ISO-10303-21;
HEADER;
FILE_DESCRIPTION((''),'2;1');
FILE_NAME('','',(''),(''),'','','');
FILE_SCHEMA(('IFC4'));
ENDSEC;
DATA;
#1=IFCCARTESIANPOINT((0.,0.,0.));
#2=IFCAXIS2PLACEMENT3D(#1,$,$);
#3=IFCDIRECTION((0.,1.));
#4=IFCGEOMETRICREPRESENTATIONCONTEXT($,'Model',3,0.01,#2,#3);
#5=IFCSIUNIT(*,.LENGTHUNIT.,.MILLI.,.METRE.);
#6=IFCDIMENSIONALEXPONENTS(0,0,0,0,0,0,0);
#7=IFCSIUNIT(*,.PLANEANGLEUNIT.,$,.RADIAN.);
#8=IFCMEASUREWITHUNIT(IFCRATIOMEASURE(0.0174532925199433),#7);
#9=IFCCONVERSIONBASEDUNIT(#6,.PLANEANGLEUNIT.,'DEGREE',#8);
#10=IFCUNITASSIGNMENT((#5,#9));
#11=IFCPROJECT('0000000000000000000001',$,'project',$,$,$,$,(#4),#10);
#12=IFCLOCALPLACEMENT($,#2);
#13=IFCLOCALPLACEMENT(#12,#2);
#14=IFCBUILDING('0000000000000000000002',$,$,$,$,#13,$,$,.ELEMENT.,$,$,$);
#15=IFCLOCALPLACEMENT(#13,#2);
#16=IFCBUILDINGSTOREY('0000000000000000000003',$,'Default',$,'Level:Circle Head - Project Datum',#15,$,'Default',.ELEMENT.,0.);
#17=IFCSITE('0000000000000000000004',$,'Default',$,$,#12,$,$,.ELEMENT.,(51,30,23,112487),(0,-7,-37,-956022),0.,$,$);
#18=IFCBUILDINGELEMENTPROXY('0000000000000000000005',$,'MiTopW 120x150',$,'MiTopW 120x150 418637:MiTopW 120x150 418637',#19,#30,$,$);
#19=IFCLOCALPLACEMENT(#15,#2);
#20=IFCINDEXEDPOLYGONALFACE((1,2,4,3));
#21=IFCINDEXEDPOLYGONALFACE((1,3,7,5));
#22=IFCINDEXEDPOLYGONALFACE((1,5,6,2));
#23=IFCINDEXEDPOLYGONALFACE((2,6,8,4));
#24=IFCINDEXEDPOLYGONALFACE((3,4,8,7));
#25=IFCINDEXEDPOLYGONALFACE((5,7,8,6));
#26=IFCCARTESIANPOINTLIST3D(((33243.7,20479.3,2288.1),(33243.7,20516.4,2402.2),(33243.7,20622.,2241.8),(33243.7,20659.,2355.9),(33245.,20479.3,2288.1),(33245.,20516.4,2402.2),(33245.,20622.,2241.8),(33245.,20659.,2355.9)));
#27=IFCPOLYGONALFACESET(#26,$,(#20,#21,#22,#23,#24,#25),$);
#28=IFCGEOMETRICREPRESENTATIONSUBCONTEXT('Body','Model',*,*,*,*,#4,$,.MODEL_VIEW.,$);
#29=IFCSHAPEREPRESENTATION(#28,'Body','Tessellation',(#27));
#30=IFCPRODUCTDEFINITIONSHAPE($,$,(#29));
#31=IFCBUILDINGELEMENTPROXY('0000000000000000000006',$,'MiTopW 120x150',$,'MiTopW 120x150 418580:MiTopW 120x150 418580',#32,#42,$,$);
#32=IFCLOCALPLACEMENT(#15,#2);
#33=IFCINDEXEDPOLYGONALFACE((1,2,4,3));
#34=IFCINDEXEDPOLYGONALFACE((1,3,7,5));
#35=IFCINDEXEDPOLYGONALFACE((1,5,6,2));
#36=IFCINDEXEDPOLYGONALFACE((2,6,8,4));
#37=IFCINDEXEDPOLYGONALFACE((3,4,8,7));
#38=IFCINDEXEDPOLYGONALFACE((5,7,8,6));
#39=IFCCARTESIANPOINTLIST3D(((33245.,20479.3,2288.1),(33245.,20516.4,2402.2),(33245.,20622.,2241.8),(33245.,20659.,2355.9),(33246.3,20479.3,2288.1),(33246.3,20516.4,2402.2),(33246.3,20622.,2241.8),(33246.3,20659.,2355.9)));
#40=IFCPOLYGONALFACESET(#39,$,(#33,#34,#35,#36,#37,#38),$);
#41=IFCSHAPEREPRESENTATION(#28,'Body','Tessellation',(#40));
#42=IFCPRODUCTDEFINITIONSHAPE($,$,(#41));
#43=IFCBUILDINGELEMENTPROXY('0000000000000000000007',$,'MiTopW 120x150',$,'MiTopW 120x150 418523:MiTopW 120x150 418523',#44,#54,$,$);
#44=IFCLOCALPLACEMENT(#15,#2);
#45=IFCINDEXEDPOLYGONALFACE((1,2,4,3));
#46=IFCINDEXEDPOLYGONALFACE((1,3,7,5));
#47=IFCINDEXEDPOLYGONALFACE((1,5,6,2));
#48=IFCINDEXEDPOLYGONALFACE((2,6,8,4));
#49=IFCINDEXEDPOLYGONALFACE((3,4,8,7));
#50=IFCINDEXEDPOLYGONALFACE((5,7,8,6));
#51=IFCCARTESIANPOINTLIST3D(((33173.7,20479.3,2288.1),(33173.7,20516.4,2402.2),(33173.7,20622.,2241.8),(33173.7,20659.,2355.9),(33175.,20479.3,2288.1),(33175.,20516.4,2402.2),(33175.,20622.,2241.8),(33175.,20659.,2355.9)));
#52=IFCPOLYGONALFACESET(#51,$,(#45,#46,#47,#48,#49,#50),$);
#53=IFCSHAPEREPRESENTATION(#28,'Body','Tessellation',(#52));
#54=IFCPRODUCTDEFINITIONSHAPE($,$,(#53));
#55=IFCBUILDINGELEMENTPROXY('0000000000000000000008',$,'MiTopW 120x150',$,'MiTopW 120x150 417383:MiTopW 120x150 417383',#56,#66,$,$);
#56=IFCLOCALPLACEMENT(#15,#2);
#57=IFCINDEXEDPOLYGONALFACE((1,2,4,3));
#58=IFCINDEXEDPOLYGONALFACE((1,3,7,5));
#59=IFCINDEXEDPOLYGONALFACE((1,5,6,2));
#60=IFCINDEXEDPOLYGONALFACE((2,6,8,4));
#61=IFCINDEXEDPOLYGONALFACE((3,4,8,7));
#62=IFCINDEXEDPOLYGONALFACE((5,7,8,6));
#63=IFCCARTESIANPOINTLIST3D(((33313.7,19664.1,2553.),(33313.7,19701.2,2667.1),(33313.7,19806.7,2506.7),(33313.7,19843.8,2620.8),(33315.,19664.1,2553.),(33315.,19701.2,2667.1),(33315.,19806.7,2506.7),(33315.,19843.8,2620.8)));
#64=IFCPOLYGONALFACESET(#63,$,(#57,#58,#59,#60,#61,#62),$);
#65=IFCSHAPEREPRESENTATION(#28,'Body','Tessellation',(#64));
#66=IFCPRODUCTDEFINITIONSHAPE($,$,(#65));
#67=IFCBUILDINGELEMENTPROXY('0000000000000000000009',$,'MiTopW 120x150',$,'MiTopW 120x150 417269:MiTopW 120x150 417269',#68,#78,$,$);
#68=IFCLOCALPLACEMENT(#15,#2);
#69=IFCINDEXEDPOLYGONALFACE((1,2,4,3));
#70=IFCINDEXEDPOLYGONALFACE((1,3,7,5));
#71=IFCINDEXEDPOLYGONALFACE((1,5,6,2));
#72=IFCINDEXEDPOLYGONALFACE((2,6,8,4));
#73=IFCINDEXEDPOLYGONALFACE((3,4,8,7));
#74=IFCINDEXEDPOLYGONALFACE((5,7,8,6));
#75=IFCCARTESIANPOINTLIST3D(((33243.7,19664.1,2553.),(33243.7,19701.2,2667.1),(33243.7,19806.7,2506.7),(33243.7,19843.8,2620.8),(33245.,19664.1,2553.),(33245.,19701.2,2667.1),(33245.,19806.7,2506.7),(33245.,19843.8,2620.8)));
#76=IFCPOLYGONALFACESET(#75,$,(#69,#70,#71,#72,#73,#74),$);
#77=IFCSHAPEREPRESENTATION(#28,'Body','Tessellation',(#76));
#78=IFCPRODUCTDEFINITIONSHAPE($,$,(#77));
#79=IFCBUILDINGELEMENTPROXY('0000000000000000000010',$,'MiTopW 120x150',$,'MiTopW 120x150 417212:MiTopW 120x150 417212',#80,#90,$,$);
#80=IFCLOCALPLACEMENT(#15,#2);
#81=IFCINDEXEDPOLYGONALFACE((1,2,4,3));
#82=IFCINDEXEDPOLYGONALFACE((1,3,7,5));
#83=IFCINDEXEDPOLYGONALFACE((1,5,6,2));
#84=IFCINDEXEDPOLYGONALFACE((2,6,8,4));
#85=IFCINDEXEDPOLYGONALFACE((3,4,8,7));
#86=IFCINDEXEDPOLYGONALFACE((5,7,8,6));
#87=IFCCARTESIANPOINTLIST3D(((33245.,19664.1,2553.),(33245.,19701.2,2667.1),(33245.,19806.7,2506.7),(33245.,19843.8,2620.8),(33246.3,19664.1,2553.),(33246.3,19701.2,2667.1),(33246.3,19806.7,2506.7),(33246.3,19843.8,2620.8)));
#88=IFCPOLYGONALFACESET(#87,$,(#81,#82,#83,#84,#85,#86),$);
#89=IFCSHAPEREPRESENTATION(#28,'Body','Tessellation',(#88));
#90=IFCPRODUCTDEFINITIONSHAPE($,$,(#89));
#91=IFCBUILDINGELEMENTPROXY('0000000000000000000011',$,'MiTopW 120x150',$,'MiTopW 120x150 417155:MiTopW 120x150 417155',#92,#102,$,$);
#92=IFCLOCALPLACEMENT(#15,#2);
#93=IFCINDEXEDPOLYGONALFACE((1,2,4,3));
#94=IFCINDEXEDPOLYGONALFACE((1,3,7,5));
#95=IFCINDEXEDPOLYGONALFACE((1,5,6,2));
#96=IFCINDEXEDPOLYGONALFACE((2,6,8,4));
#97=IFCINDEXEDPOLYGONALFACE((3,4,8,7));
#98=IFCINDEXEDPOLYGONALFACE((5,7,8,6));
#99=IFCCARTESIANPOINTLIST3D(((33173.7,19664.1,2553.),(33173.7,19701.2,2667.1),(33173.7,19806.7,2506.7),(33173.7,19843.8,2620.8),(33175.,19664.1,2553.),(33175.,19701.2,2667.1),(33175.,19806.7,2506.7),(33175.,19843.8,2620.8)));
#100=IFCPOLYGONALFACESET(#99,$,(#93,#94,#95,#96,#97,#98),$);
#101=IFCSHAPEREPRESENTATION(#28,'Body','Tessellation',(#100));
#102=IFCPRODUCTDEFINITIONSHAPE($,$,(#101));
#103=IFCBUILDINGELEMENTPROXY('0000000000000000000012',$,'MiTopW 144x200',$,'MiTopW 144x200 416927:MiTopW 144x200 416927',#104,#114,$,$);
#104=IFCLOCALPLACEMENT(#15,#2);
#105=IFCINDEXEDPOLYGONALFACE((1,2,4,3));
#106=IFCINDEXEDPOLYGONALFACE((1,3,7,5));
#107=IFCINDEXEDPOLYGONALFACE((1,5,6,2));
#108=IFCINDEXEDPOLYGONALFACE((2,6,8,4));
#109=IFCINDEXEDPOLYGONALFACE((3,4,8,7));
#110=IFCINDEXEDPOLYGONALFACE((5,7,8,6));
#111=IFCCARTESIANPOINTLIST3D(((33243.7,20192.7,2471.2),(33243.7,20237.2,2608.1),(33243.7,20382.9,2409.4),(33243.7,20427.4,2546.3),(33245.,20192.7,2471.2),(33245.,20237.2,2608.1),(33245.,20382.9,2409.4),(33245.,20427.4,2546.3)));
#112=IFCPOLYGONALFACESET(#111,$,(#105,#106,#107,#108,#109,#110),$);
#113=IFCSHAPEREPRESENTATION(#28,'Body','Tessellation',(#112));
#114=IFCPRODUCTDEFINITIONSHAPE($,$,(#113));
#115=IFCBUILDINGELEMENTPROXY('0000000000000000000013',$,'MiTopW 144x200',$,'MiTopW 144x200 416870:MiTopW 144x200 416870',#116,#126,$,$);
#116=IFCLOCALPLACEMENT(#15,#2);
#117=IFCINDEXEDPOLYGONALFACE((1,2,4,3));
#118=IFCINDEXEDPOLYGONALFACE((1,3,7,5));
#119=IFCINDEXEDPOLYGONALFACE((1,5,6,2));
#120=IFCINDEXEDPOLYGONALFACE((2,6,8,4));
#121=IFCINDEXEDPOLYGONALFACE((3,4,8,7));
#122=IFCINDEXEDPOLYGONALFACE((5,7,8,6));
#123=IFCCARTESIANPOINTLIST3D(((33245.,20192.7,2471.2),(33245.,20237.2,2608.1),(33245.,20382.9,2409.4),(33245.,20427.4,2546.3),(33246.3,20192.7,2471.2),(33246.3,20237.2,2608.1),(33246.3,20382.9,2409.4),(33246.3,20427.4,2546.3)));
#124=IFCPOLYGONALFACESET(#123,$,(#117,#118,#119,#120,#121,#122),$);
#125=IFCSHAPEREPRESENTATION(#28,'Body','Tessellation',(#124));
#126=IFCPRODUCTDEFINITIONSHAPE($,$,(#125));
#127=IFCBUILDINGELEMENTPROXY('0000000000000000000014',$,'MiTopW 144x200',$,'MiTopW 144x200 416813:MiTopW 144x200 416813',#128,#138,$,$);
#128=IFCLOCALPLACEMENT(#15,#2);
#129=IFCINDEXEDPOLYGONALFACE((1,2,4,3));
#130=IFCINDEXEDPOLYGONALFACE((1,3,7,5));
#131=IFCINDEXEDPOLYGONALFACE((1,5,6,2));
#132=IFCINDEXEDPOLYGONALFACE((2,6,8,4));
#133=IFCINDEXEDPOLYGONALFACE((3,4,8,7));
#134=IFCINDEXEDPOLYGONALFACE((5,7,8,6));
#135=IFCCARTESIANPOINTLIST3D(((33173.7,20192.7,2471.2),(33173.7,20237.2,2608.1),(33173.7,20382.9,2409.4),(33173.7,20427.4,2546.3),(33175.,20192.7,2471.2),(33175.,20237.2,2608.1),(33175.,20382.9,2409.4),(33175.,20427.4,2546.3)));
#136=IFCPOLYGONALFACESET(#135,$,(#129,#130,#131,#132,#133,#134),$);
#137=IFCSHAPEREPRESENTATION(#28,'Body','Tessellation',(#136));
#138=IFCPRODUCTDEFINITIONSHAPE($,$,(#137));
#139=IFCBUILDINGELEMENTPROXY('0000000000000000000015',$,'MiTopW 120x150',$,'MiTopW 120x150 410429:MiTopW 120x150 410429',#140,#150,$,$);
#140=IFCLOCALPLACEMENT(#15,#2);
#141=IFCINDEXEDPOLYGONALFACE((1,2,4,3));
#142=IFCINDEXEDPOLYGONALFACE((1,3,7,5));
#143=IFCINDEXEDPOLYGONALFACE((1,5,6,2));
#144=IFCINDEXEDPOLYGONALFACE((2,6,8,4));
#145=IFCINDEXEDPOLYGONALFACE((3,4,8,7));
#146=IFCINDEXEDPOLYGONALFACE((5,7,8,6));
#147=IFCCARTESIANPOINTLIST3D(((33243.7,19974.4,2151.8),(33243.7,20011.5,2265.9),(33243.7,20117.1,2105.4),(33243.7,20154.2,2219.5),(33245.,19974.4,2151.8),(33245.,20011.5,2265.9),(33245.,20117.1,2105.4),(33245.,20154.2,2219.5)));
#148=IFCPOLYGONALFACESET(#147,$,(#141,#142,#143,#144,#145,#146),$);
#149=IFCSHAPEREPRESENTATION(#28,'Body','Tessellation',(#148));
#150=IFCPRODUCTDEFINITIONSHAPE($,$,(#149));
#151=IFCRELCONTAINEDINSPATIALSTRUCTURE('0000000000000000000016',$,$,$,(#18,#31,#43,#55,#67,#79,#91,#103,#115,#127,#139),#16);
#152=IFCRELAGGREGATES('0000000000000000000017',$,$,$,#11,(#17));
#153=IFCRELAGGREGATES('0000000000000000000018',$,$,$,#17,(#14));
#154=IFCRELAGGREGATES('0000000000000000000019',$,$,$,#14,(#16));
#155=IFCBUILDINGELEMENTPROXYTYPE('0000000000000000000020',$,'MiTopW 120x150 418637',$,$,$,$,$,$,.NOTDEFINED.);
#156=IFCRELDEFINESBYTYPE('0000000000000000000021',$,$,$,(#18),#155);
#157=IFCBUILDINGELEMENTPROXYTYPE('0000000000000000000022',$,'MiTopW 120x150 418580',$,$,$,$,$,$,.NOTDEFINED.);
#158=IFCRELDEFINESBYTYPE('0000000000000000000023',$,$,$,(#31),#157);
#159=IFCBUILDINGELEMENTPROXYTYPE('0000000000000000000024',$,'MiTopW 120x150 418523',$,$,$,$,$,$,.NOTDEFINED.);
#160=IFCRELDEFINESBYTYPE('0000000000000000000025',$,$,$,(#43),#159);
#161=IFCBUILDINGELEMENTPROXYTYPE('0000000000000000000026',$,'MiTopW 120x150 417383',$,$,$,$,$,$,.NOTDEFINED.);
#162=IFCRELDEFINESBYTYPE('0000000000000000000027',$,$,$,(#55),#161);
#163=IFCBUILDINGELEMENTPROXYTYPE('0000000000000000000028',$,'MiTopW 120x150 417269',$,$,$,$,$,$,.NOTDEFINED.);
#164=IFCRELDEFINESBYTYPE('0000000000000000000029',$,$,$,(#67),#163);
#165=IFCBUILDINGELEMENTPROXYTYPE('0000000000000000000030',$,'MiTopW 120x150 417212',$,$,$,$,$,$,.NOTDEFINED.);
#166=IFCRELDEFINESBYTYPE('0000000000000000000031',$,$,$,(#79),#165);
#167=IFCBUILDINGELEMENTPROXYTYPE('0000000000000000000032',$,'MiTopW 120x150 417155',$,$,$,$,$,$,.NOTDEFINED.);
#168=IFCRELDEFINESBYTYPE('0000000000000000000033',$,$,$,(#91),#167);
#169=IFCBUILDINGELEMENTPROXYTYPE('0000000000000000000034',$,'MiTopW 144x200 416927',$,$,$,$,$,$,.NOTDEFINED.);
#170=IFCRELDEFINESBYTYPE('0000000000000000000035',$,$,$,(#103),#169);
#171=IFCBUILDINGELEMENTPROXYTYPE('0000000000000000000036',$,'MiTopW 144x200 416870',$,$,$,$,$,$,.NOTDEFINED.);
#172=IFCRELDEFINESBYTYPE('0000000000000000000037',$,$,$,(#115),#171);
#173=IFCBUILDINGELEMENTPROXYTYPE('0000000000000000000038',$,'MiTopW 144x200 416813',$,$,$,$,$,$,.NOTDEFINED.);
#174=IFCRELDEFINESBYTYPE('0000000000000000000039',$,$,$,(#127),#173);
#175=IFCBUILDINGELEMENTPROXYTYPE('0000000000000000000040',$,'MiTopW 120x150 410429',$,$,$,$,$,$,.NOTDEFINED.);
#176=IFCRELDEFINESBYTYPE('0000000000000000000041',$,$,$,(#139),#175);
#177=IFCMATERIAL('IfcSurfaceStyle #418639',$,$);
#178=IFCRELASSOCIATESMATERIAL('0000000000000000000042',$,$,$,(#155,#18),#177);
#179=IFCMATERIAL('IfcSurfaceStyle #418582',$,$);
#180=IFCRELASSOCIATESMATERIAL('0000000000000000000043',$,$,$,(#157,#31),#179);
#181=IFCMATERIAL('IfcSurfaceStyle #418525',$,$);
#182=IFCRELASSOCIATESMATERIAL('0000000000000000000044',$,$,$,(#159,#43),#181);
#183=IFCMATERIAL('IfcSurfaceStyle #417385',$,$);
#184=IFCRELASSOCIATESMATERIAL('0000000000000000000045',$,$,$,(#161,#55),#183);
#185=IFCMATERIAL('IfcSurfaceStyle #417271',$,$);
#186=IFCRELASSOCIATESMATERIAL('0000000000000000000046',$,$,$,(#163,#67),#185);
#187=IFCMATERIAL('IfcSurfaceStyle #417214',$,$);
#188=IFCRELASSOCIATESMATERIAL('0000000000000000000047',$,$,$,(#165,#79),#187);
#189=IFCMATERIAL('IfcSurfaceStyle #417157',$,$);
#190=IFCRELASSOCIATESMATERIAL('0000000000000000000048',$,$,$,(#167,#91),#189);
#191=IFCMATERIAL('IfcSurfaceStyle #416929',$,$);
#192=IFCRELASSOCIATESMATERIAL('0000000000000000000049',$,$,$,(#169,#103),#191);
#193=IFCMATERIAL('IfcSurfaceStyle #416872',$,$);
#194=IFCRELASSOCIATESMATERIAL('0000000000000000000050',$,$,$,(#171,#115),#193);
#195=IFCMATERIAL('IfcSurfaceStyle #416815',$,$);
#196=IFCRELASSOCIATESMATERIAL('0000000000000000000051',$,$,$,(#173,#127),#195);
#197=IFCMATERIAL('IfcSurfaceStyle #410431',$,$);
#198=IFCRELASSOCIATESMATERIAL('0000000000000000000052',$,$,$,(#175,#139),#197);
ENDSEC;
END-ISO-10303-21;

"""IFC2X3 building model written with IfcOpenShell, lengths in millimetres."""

from ifc_helpers import new_model, entity, si_unit, converted_unit, direction, frame, origin, place, context, subcontext, project, spatial, polyline, outline, extrude, source, transform, mapped, material, type_object, type_shapes, element, save


model = new_model("IFC2X3")

# Units and contexts
model_context = context("Model", 3, precision=0.01, world=origin(), true_north=direction((0.0, 1.0)))
body_context = subcontext(model_context, "Body", "Model", "MODEL_VIEW")
ifc_project = project(units=[si_unit("LENGTHUNIT", "METRE", prefix="MILLI"), converted_unit("PLANEANGLEUNIT", "DEGREE", entity("IfcRatioMeasure", 0.0174532925199433), si_unit("PLANEANGLEUNIT", "RADIAN"), dimensions=[0, 0, 0, 0, 0, 0, 0])], contexts=[model_context])

# Site, building, storey
site_placement = place(None, origin())
site = spatial("IfcSite", under=ifc_project, at=site_placement, Name="Default", CompositionType="ELEMENT", RefLatitude=(51, 30, 23, 112487), RefLongitude=(0, -7, -37, -956022), RefElevation=0.0)
building_placement = place(site_placement, origin())
building = spatial("IfcBuilding", under=site, at=building_placement, CompositionType="ELEMENT")
storey_placement = place(building_placement, origin())
storey = spatial("IfcBuildingStorey", under=building, at=storey_placement, Name="Default", ObjectType="Level:Circle Head - Project Datum", LongName="Default", CompositionType="ELEMENT", Elevation=0.0)

# Building element proxies
ifc_material_1 = material(Name="IfcSurfaceStyle #418639")
building_element_proxy_type_1 = type_object("IfcBuildingElementProxyType", Name="MiTopW 120x150 418637", PredefinedType="NOTDEFINED", material=ifc_material_1)
shared_shape_1 = source(origin(), body_context, "Body", "SweptSolid", [
    extrude(outline(polyline([(-75.0, -60.0), (75.0, -60.0), (75.0, 60.0), (-75.0, 60.0), (-75.0, -60.0)])), frame((75.0, 60.0, 0.0), z_axis=(0.0, 0.0, 1.0), x_axis=(-1.0, 0.0, 0.0)), (0.0, 0.0, 1.0), 1.3),
])
type_shapes(building_element_proxy_type_1, [shared_shape_1])
proxy_1_placement = place(building_placement, frame((33245.0, 20622.0, 2241.8), z_axis=(-1.0, 0.0, 0.0), x_axis=(0.0, -0.951057, 0.309017)))
element("IfcBuildingElementProxy", 1, at=proxy_1_placement, inside=storey, type_object=building_element_proxy_type_1, material=ifc_material_1, Name="MiTopW 120x150", ObjectType="MiTopW 120x150 418637:MiTopW 120x150 418637", context=body_context, shape_type="MappedRepresentation", body=[
    mapped(shared_shape_1, transform((0.0, 0.0, 0.0), scale=1.0)),
])
ifc_material_2 = material(Name="IfcSurfaceStyle #418582")
building_element_proxy_type_2 = type_object("IfcBuildingElementProxyType", Name="MiTopW 120x150 418580", PredefinedType="NOTDEFINED", material=ifc_material_2)
shared_shape_2 = source(origin(), body_context, "Body", "SweptSolid", [
    extrude(outline(polyline([(-75.0, -60.0), (75.0, -60.0), (75.0, 60.0), (-75.0, 60.0), (-75.0, -60.0)])), frame((75.0, 60.0, 0.0), z_axis=(0.0, 0.0, 1.0), x_axis=(-1.0, 0.0, 0.0)), (0.0, 0.0, 1.0), 1.3),
])
type_shapes(building_element_proxy_type_2, [shared_shape_2])
proxy_2_placement = place(building_placement, frame((33246.3, 20622.0, 2241.8), z_axis=(-1.0, 0.0, 0.0), x_axis=(0.0, -0.951057, 0.309017)))
element("IfcBuildingElementProxy", 2, at=proxy_2_placement, inside=storey, type_object=building_element_proxy_type_2, material=ifc_material_2, Name="MiTopW 120x150", ObjectType="MiTopW 120x150 418580:MiTopW 120x150 418580", context=body_context, shape_type="MappedRepresentation", body=[
    mapped(shared_shape_2, transform((0.0, 0.0, 0.0), scale=1.0)),
])
ifc_material_3 = material(Name="IfcSurfaceStyle #418525")
building_element_proxy_type_3 = type_object("IfcBuildingElementProxyType", Name="MiTopW 120x150 418523", PredefinedType="NOTDEFINED", material=ifc_material_3)
shared_shape_3 = source(origin(), body_context, "Body", "SweptSolid", [
    extrude(outline(polyline([(-75.0, -60.0), (75.0, -60.0), (75.0, 60.0), (-75.0, 60.0), (-75.0, -60.0)])), frame((75.0, 60.0, 0.0), z_axis=(0.0, 0.0, 1.0), x_axis=(-1.0, 0.0, 0.0)), (0.0, 0.0, 1.0), 1.3),
])
type_shapes(building_element_proxy_type_3, [shared_shape_3])
proxy_3_placement = place(building_placement, frame((33175.0, 20622.0, 2241.8), z_axis=(-1.0, 0.0, 0.0), x_axis=(0.0, -0.951057, 0.309017)))
element("IfcBuildingElementProxy", 3, at=proxy_3_placement, inside=storey, type_object=building_element_proxy_type_3, material=ifc_material_3, Name="MiTopW 120x150", ObjectType="MiTopW 120x150 418523:MiTopW 120x150 418523", context=body_context, shape_type="MappedRepresentation", body=[
    mapped(shared_shape_3, transform((0.0, 0.0, 0.0), scale=1.0)),
])
ifc_material_4 = material(Name="IfcSurfaceStyle #417385")
building_element_proxy_type_4 = type_object("IfcBuildingElementProxyType", Name="MiTopW 120x150 417383", PredefinedType="NOTDEFINED", material=ifc_material_4)
shared_shape_4 = source(origin(), body_context, "Body", "SweptSolid", [
    extrude(outline(polyline([(-75.0, -60.0), (75.0, -60.0), (75.0, 60.0), (-75.0, 60.0), (-75.0, -60.0)])), frame((75.0, 60.0, 0.0), z_axis=(0.0, 0.0, 1.0), x_axis=(-1.0, 0.0, 0.0)), (0.0, 0.0, 1.0), 1.3),
])
type_shapes(building_element_proxy_type_4, [shared_shape_4])
proxy_4_placement = place(building_placement, frame((33315.0, 19806.7, 2506.7), z_axis=(-1.0, 0.0, 0.0), x_axis=(0.0, -0.951057, 0.309017)))
element("IfcBuildingElementProxy", 4, at=proxy_4_placement, inside=storey, type_object=building_element_proxy_type_4, material=ifc_material_4, Name="MiTopW 120x150", ObjectType="MiTopW 120x150 417383:MiTopW 120x150 417383", context=body_context, shape_type="MappedRepresentation", body=[
    mapped(shared_shape_4, transform((0.0, 0.0, 0.0), scale=1.0)),
])
ifc_material_5 = material(Name="IfcSurfaceStyle #417271")
building_element_proxy_type_5 = type_object("IfcBuildingElementProxyType", Name="MiTopW 120x150 417269", PredefinedType="NOTDEFINED", material=ifc_material_5)
shared_shape_5 = source(origin(), body_context, "Body", "SweptSolid", [
    extrude(outline(polyline([(-75.0, -60.0), (75.0, -60.0), (75.0, 60.0), (-75.0, 60.0), (-75.0, -60.0)])), frame((75.0, 60.0, 0.0), z_axis=(0.0, 0.0, 1.0), x_axis=(-1.0, 0.0, 0.0)), (0.0, 0.0, 1.0), 1.3),
])
type_shapes(building_element_proxy_type_5, [shared_shape_5])
proxy_5_placement = place(building_placement, frame((33245.0, 19806.7, 2506.7), z_axis=(-1.0, 0.0, 0.0), x_axis=(0.0, -0.951057, 0.309017)))
element("IfcBuildingElementProxy", 5, at=proxy_5_placement, inside=storey, type_object=building_element_proxy_type_5, material=ifc_material_5, Name="MiTopW 120x150", ObjectType="MiTopW 120x150 417269:MiTopW 120x150 417269", context=body_context, shape_type="MappedRepresentation", body=[
    mapped(shared_shape_5, transform((0.0, 0.0, 0.0), scale=1.0)),
])
ifc_material_6 = material(Name="IfcSurfaceStyle #417214")
building_element_proxy_type_6 = type_object("IfcBuildingElementProxyType", Name="MiTopW 120x150 417212", PredefinedType="NOTDEFINED", material=ifc_material_6)
shared_shape_6 = source(origin(), body_context, "Body", "SweptSolid", [
    extrude(outline(polyline([(-75.0, -60.0), (75.0, -60.0), (75.0, 60.0), (-75.0, 60.0), (-75.0, -60.0)])), frame((75.0, 60.0, 0.0), z_axis=(0.0, 0.0, 1.0), x_axis=(-1.0, 0.0, 0.0)), (0.0, 0.0, 1.0), 1.3),
])
type_shapes(building_element_proxy_type_6, [shared_shape_6])
proxy_6_placement = place(building_placement, frame((33246.3, 19806.7, 2506.7), z_axis=(-1.0, 0.0, 0.0), x_axis=(0.0, -0.951057, 0.309017)))
element("IfcBuildingElementProxy", 6, at=proxy_6_placement, inside=storey, type_object=building_element_proxy_type_6, material=ifc_material_6, Name="MiTopW 120x150", ObjectType="MiTopW 120x150 417212:MiTopW 120x150 417212", context=body_context, shape_type="MappedRepresentation", body=[
    mapped(shared_shape_6, transform((0.0, 0.0, 0.0), scale=1.0)),
])
ifc_material_7 = material(Name="IfcSurfaceStyle #417157")
building_element_proxy_type_7 = type_object("IfcBuildingElementProxyType", Name="MiTopW 120x150 417155", PredefinedType="NOTDEFINED", material=ifc_material_7)
shared_shape_7 = source(origin(), body_context, "Body", "SweptSolid", [
    extrude(outline(polyline([(-75.0, -60.0), (75.0, -60.0), (75.0, 60.0), (-75.0, 60.0), (-75.0, -60.0)])), frame((75.0, 60.0, 0.0), z_axis=(0.0, 0.0, 1.0), x_axis=(-1.0, 0.0, 0.0)), (0.0, 0.0, 1.0), 1.3),
])
type_shapes(building_element_proxy_type_7, [shared_shape_7])
proxy_7_placement = place(building_placement, frame((33175.0, 19806.7, 2506.7), z_axis=(-1.0, 0.0, 0.0), x_axis=(0.0, -0.951057, 0.309017)))
element("IfcBuildingElementProxy", 7, at=proxy_7_placement, inside=storey, type_object=building_element_proxy_type_7, material=ifc_material_7, Name="MiTopW 120x150", ObjectType="MiTopW 120x150 417155:MiTopW 120x150 417155", context=body_context, shape_type="MappedRepresentation", body=[
    mapped(shared_shape_7, transform((0.0, 0.0, 0.0), scale=1.0)),
])
ifc_material_8 = material(Name="IfcSurfaceStyle #416929")
building_element_proxy_type_8 = type_object("IfcBuildingElementProxyType", Name="MiTopW 144x200 416927", PredefinedType="NOTDEFINED", material=ifc_material_8)
shared_shape_8 = source(origin(), body_context, "Body", "SweptSolid", [
    extrude(outline(polyline([(-100.0, -72.0), (100.0, -72.0), (100.0, 72.0), (-100.0, 72.0), (-100.0, -72.0)])), frame((100.0, 72.0, 0.0), z_axis=(0.0, 0.0, 1.0), x_axis=(-1.0, 0.0, 0.0)), (0.0, 0.0, 1.0), 1.3),
])
type_shapes(building_element_proxy_type_8, [shared_shape_8])
proxy_8_placement = place(building_placement, frame((33245.0, 20382.9, 2409.4), z_axis=(-1.0, 0.0, 0.0), x_axis=(0.0, -0.951057, 0.309017)))
element("IfcBuildingElementProxy", 8, at=proxy_8_placement, inside=storey, type_object=building_element_proxy_type_8, material=ifc_material_8, Name="MiTopW 144x200", ObjectType="MiTopW 144x200 416927:MiTopW 144x200 416927", context=body_context, shape_type="MappedRepresentation", body=[
    mapped(shared_shape_8, transform((0.0, 0.0, 0.0), scale=1.0)),
])
ifc_material_9 = material(Name="IfcSurfaceStyle #416872")
building_element_proxy_type_9 = type_object("IfcBuildingElementProxyType", Name="MiTopW 144x200 416870", PredefinedType="NOTDEFINED", material=ifc_material_9)
shared_shape_9 = source(origin(), body_context, "Body", "SweptSolid", [
    extrude(outline(polyline([(-100.0, -72.0), (100.0, -72.0), (100.0, 72.0), (-100.0, 72.0), (-100.0, -72.0)])), frame((100.0, 72.0, 0.0), z_axis=(0.0, 0.0, 1.0), x_axis=(-1.0, 0.0, 0.0)), (0.0, 0.0, 1.0), 1.3),
])
type_shapes(building_element_proxy_type_9, [shared_shape_9])
proxy_9_placement = place(building_placement, frame((33246.3, 20382.9, 2409.4), z_axis=(-1.0, 0.0, 0.0), x_axis=(0.0, -0.951057, 0.309017)))
element("IfcBuildingElementProxy", 9, at=proxy_9_placement, inside=storey, type_object=building_element_proxy_type_9, material=ifc_material_9, Name="MiTopW 144x200", ObjectType="MiTopW 144x200 416870:MiTopW 144x200 416870", context=body_context, shape_type="MappedRepresentation", body=[
    mapped(shared_shape_9, transform((0.0, 0.0, 0.0), scale=1.0)),
])
ifc_material_10 = material(Name="IfcSurfaceStyle #416815")
building_element_proxy_type_10 = type_object("IfcBuildingElementProxyType", Name="MiTopW 144x200 416813", PredefinedType="NOTDEFINED", material=ifc_material_10)
shared_shape_10 = source(origin(), body_context, "Body", "SweptSolid", [
    extrude(outline(polyline([(-100.0, -72.0), (100.0, -72.0), (100.0, 72.0), (-100.0, 72.0), (-100.0, -72.0)])), frame((100.0, 72.0, 0.0), z_axis=(0.0, 0.0, 1.0), x_axis=(-1.0, 0.0, 0.0)), (0.0, 0.0, 1.0), 1.3),
])
type_shapes(building_element_proxy_type_10, [shared_shape_10])
proxy_10_placement = place(building_placement, frame((33175.0, 20382.9, 2409.4), z_axis=(-1.0, 0.0, 0.0), x_axis=(0.0, -0.951057, 0.309017)))
element("IfcBuildingElementProxy", 10, at=proxy_10_placement, inside=storey, type_object=building_element_proxy_type_10, material=ifc_material_10, Name="MiTopW 144x200", ObjectType="MiTopW 144x200 416813:MiTopW 144x200 416813", context=body_context, shape_type="MappedRepresentation", body=[
    mapped(shared_shape_10, transform((0.0, 0.0, 0.0), scale=1.0)),
])
ifc_material_11 = material(Name="IfcSurfaceStyle #410431")
building_element_proxy_type_11 = type_object("IfcBuildingElementProxyType", Name="MiTopW 120x150 410429", PredefinedType="NOTDEFINED", material=ifc_material_11)
shared_shape_11 = source(origin(), body_context, "Body", "SweptSolid", [
    extrude(outline(polyline([(-75.0, -60.0), (75.0, -60.0), (75.0, 60.0), (-75.0, 60.0), (-75.0, -60.0)])), frame((75.0, 60.0, 0.0), z_axis=(0.0, 0.0, 1.0), x_axis=(-1.0, 0.0, 0.0)), (0.0, 0.0, 1.0), 1.3),
])
type_shapes(building_element_proxy_type_11, [shared_shape_11])
proxy_11_placement = place(building_placement, frame((33245.0, 20117.1, 2105.4), z_axis=(-1.0, 0.0, 0.0), x_axis=(0.0, -0.951057, 0.309017)))
element("IfcBuildingElementProxy", 11, at=proxy_11_placement, inside=storey, type_object=building_element_proxy_type_11, material=ifc_material_11, Name="MiTopW 120x150", ObjectType="MiTopW 120x150 410429:MiTopW 120x150 410429", context=body_context, shape_type="MappedRepresentation", body=[
    mapped(shared_shape_11, transform((0.0, 0.0, 0.0), scale=1.0)),
])

save(model, "model.ifc")
